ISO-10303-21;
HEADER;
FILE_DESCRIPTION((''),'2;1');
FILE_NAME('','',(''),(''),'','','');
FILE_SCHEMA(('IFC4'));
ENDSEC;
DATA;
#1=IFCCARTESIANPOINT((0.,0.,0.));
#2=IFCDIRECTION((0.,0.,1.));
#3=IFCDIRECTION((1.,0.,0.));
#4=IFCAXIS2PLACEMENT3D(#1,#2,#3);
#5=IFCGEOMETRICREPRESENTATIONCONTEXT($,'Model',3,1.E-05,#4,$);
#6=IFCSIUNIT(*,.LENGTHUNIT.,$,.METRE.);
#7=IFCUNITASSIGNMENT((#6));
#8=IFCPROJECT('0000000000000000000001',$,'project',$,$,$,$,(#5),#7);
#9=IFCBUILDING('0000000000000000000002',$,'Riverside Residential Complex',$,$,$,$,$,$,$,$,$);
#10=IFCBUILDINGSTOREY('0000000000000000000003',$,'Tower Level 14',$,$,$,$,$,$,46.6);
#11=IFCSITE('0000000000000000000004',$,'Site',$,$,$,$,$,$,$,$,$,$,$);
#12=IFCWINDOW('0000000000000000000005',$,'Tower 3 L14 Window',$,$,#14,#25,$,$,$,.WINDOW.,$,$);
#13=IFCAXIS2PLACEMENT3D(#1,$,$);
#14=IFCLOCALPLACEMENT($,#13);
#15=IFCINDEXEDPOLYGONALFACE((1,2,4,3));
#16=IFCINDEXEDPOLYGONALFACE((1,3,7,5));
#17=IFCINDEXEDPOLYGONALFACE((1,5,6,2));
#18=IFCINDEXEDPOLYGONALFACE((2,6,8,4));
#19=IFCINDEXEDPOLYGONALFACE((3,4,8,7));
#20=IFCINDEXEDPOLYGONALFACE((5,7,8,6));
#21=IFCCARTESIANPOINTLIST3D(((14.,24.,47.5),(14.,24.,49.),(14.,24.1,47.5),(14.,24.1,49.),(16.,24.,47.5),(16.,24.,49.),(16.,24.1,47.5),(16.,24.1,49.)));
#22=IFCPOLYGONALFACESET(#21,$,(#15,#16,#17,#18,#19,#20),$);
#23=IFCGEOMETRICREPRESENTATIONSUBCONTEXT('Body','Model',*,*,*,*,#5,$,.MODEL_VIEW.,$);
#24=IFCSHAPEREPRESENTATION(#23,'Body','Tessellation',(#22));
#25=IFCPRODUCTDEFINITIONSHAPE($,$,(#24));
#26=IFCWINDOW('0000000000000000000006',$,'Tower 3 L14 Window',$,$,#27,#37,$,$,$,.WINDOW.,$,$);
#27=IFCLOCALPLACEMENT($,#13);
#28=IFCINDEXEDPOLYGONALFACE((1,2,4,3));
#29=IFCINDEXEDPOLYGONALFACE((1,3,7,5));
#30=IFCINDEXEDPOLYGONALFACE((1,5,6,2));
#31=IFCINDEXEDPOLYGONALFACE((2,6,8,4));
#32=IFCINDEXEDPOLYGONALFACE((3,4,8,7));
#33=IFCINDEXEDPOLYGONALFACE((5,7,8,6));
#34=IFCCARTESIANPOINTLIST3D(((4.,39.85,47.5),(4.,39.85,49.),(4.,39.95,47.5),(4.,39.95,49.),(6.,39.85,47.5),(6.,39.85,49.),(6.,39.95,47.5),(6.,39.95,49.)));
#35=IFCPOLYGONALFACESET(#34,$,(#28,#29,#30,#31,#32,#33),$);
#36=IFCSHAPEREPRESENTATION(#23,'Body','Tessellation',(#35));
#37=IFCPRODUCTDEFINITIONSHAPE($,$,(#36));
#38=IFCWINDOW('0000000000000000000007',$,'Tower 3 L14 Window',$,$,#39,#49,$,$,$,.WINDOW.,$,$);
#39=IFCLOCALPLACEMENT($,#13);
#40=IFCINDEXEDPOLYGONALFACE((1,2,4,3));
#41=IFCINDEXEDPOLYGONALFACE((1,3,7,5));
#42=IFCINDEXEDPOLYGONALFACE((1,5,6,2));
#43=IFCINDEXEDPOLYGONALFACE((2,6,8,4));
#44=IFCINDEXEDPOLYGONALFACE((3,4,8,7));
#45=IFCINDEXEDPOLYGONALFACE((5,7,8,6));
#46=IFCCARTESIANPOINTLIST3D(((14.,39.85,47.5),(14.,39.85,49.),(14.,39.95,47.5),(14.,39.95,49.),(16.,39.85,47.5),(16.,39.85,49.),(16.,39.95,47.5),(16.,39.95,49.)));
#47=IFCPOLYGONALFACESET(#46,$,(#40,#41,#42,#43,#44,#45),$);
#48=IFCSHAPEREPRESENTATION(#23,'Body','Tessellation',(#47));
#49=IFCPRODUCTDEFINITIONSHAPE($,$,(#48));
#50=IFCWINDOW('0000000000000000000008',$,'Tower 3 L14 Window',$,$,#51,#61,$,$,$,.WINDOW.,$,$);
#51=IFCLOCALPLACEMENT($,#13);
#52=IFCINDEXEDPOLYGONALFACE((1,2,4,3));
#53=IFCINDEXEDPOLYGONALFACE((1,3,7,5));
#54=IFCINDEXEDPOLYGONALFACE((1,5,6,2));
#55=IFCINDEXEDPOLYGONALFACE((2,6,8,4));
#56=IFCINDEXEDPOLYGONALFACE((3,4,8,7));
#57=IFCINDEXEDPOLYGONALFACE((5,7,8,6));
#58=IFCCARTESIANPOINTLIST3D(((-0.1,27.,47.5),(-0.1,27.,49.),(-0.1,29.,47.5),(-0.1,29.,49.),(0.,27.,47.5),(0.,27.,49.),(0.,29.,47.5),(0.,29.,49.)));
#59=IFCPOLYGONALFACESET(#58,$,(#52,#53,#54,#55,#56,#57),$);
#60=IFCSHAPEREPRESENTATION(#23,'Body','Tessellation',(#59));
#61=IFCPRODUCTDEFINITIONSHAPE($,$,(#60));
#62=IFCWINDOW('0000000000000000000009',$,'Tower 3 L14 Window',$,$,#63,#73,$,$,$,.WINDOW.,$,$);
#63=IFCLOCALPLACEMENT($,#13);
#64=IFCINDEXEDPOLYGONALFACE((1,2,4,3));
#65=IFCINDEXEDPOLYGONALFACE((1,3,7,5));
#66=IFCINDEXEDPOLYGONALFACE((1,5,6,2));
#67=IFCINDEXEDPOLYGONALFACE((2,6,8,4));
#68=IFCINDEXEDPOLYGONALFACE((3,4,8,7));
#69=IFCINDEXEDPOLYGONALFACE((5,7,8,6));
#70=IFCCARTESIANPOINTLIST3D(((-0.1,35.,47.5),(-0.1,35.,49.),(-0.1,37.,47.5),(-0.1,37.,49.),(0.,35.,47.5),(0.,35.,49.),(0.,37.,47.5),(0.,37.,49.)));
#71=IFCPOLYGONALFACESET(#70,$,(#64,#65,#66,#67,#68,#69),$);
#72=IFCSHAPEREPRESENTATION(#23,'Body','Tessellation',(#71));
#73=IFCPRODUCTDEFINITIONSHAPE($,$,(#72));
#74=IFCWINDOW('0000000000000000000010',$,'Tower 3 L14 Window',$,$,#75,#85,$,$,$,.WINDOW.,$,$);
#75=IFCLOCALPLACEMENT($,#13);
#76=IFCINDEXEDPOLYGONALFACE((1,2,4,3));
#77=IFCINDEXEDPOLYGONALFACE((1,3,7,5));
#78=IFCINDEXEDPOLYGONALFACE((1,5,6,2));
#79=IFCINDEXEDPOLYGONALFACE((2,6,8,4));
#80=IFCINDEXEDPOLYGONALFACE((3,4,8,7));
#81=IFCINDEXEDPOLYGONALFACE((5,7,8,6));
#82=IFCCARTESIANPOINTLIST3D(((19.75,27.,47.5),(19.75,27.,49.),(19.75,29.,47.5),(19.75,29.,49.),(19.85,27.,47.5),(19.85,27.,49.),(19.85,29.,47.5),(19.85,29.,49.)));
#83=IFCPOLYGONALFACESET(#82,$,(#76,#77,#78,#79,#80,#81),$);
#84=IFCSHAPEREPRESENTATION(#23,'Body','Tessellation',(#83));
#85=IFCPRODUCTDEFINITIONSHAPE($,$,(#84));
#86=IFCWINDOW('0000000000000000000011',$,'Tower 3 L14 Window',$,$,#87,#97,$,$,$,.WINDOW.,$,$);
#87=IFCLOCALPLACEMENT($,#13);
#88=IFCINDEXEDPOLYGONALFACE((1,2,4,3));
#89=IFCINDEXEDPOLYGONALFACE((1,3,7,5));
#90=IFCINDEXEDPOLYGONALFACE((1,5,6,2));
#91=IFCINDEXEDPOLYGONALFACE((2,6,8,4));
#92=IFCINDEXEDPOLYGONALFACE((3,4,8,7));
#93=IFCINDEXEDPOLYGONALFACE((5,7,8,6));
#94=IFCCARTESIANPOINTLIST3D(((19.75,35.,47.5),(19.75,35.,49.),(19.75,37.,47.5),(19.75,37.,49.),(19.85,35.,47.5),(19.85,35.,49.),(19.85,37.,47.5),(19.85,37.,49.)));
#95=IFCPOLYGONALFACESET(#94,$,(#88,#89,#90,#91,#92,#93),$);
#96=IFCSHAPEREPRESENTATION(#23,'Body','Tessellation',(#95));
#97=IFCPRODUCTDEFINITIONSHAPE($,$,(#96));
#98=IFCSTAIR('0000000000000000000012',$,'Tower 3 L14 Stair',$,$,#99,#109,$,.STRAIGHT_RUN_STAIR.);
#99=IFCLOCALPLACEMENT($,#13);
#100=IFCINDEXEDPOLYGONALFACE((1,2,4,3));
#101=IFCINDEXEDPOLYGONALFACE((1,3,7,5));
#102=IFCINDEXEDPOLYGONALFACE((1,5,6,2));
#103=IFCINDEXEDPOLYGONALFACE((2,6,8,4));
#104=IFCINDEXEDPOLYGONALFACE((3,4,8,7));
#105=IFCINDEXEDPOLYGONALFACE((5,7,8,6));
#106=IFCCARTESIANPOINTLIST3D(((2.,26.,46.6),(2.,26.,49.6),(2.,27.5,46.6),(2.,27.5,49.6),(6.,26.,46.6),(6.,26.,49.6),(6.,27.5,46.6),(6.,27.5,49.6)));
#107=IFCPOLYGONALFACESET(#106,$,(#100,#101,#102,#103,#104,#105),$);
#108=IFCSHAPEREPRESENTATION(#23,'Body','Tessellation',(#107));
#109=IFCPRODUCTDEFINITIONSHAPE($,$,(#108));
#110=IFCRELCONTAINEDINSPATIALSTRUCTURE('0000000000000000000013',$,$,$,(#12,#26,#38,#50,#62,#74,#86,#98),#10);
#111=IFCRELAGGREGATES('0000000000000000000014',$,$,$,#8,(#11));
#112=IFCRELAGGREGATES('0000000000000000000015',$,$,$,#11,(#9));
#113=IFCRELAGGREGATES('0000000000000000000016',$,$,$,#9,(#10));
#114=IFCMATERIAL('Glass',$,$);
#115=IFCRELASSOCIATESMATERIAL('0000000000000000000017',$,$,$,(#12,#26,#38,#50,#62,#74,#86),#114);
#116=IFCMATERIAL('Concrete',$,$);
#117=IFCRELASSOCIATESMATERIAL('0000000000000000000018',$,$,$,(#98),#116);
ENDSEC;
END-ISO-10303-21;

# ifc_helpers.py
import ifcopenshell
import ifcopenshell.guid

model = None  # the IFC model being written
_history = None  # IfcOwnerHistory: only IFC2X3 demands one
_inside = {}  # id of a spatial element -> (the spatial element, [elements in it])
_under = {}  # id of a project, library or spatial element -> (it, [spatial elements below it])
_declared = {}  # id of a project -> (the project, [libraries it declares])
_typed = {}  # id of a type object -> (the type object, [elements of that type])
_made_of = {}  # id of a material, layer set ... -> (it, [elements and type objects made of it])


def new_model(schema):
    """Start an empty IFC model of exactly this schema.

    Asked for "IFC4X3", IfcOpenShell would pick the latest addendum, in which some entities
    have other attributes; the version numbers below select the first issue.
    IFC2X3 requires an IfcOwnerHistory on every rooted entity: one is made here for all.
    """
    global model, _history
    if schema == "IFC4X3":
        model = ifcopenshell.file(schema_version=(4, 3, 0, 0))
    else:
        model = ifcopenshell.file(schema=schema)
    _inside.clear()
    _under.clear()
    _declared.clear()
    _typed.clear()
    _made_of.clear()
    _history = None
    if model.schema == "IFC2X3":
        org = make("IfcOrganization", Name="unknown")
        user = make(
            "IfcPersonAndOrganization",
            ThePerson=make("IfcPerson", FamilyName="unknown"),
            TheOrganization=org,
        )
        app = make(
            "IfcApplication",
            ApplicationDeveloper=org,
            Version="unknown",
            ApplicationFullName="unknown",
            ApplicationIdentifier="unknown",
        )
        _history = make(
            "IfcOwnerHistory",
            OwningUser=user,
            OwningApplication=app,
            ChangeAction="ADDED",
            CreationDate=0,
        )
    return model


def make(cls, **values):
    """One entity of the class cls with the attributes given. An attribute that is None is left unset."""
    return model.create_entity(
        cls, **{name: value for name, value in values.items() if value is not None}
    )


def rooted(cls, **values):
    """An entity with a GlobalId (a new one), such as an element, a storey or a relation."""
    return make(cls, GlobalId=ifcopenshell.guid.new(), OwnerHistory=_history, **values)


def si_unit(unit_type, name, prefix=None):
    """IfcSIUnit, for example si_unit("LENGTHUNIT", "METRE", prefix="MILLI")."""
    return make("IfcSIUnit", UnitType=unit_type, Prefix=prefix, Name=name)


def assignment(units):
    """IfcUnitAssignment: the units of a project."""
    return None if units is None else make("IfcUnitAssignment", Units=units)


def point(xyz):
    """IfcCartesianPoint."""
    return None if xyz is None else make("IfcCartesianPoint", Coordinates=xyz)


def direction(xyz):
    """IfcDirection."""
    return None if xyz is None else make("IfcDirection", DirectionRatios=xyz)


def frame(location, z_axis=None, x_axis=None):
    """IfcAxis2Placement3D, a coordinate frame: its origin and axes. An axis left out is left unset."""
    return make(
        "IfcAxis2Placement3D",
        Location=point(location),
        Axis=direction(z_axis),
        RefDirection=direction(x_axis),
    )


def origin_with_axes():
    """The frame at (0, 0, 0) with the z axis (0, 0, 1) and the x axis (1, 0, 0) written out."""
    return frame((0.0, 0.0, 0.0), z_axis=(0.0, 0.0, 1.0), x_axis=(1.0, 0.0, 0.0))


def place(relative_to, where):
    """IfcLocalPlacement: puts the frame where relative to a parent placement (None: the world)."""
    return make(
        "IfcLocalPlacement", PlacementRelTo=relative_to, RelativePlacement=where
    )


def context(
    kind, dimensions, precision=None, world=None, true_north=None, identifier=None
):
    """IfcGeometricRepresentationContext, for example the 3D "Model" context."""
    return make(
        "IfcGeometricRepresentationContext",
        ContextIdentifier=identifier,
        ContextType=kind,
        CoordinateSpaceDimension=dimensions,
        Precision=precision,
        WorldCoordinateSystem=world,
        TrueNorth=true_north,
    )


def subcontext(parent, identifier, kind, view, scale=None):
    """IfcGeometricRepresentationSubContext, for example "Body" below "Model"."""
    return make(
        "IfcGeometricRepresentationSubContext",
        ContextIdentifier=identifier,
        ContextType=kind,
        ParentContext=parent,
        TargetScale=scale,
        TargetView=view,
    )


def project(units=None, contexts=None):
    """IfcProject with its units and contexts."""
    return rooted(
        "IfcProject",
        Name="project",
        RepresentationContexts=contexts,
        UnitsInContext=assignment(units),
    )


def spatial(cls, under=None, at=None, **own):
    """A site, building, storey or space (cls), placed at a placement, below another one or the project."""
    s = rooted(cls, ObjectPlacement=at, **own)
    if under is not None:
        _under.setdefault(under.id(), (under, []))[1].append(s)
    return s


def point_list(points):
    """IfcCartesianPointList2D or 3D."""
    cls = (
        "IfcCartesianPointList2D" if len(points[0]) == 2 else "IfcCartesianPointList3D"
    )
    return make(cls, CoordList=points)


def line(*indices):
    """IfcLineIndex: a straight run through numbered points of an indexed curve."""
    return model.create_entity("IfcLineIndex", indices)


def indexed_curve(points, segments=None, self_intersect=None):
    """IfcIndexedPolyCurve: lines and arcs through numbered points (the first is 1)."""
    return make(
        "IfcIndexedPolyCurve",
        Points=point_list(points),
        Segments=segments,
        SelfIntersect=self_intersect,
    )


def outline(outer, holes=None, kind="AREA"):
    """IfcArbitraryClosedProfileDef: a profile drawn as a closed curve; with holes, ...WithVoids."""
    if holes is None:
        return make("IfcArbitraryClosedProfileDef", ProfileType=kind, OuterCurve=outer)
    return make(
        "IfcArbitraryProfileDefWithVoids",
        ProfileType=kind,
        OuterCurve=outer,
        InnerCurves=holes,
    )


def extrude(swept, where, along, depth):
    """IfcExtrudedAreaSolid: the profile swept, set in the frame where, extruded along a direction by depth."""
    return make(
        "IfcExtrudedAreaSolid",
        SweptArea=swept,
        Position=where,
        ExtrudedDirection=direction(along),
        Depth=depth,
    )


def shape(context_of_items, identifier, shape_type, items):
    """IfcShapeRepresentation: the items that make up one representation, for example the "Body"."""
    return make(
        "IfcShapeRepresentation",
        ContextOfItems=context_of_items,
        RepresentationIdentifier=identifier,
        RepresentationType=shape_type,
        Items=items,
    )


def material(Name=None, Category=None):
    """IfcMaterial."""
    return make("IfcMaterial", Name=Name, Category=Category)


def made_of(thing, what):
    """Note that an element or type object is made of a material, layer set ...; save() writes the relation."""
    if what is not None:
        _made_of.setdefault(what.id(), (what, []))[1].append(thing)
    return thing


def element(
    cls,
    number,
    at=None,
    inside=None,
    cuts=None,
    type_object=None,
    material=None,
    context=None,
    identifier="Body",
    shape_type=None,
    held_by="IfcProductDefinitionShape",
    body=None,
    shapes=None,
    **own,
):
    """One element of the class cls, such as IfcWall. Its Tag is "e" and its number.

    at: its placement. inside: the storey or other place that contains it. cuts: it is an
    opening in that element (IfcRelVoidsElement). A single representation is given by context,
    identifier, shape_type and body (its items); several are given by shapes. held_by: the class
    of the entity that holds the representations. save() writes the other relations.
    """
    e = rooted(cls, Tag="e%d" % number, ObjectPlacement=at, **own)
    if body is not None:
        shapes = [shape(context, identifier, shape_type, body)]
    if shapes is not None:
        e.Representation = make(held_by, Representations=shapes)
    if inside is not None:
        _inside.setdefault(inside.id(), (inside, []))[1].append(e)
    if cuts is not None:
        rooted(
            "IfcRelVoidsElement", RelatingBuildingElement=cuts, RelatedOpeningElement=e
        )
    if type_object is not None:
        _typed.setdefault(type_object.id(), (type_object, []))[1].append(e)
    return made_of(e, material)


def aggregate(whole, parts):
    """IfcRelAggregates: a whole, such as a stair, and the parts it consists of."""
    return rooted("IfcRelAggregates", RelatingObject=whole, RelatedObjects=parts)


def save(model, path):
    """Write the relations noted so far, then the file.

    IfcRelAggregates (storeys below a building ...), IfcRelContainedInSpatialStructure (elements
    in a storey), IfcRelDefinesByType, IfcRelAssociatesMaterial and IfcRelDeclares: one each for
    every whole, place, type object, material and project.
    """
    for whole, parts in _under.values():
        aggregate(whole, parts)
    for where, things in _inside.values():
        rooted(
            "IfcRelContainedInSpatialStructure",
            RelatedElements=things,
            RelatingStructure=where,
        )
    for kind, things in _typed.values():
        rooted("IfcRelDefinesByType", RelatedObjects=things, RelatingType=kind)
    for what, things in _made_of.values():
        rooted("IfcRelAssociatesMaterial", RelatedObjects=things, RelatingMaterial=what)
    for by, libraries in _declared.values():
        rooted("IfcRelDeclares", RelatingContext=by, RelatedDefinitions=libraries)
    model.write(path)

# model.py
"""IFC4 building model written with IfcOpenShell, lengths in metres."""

from ifc_helpers import new_model, si_unit, frame, origin_with_axes, place, context, subcontext, project, spatial, line, indexed_curve, outline, extrude, material, element, save


model = new_model("IFC4")

# Units and contexts
model_context = context("Model", 3, precision=1e-05, world=origin_with_axes())
body_context = subcontext(model_context, "Body", "Model", "MODEL_VIEW")
ifc_project = project(units=[si_unit("LENGTHUNIT", "METRE")], contexts=[model_context])

# Site, building, storey
site = spatial("IfcSite", under=ifc_project, Name="Site")
building = spatial("IfcBuilding", under=site, Name="Riverside Residential Complex")
storey = spatial("IfcBuildingStorey", under=building, Name="Tower Level 14", Elevation=46.6)

# Shared definitions
ifc_material_1 = material(Name="Concrete")

# Windows
ifc_material_2 = material(Name="Glass")
for number, where, z_axis, x_axis, name in (
    (1, (14.0, 24.0, 47.5), (0.0, 0.0, 1.0), (1.0, 0.0, 0.0), "Tower 3 L14 Window"),
    (2, (4.0, 39.85, 47.5), (0.0, 0.0, 1.0), (1.0, 0.0, 0.0), "Tower 3 L14 Window"),
    (3, (14.0, 39.85, 47.5), (0.0, 0.0, 1.0), (1.0, 0.0, 0.0), "Tower 3 L14 Window"),
    (4, (0.0, 27.0, 47.5), (0.0, 0.0, 1.0), (0.0, 1.0, 0.0), "Tower 3 L14 Window"),
    (5, (0.0, 35.0, 47.5), (0.0, 0.0, 1.0), (0.0, 1.0, 0.0), "Tower 3 L14 Window"),
    (6, (19.85, 27.0, 47.5), (0.0, 0.0, 1.0), (0.0, 1.0, 0.0), "Tower 3 L14 Window"),
    (7, (19.85, 35.0, 47.5), (0.0, 0.0, 1.0), (0.0, 1.0, 0.0), "Tower 3 L14 Window"),
):
    element("IfcWindow", number, at=place(None, frame(where, z_axis=z_axis, x_axis=x_axis)), inside=storey, material=ifc_material_2, Name=name, PredefinedType="WINDOW", context=body_context, shape_type="SweptSolid", body=[
        extrude(outline(indexed_curve([(0.0, 0.0), (2.0, 0.0), (2.0, 0.1), (0.0, 0.1)], segments=[line(1, 2, 3, 4, 1)])), origin_with_axes(), (0.0, 0.0, 1.0), 1.5),
    ])

# Stair
stair_placement = place(None, frame((2.0, 26.0, 46.6), z_axis=(0.0, 0.0, 1.0), x_axis=(1.0, 0.0, 0.0)))
element("IfcStair", 8, at=stair_placement, inside=storey, material=ifc_material_1, Name="Tower 3 L14 Stair", PredefinedType="STRAIGHT_RUN_STAIR", context=body_context, shape_type="SweptSolid", body=[
    extrude(outline(indexed_curve([(0.0, 0.0), (4.0, 0.0), (4.0, 1.5), (0.0, 1.5)], segments=[line(1, 2, 3, 4, 1)])), origin_with_axes(), (0.0, 0.0, 1.0), 3.0),
])

save(model, "model.ifc")
